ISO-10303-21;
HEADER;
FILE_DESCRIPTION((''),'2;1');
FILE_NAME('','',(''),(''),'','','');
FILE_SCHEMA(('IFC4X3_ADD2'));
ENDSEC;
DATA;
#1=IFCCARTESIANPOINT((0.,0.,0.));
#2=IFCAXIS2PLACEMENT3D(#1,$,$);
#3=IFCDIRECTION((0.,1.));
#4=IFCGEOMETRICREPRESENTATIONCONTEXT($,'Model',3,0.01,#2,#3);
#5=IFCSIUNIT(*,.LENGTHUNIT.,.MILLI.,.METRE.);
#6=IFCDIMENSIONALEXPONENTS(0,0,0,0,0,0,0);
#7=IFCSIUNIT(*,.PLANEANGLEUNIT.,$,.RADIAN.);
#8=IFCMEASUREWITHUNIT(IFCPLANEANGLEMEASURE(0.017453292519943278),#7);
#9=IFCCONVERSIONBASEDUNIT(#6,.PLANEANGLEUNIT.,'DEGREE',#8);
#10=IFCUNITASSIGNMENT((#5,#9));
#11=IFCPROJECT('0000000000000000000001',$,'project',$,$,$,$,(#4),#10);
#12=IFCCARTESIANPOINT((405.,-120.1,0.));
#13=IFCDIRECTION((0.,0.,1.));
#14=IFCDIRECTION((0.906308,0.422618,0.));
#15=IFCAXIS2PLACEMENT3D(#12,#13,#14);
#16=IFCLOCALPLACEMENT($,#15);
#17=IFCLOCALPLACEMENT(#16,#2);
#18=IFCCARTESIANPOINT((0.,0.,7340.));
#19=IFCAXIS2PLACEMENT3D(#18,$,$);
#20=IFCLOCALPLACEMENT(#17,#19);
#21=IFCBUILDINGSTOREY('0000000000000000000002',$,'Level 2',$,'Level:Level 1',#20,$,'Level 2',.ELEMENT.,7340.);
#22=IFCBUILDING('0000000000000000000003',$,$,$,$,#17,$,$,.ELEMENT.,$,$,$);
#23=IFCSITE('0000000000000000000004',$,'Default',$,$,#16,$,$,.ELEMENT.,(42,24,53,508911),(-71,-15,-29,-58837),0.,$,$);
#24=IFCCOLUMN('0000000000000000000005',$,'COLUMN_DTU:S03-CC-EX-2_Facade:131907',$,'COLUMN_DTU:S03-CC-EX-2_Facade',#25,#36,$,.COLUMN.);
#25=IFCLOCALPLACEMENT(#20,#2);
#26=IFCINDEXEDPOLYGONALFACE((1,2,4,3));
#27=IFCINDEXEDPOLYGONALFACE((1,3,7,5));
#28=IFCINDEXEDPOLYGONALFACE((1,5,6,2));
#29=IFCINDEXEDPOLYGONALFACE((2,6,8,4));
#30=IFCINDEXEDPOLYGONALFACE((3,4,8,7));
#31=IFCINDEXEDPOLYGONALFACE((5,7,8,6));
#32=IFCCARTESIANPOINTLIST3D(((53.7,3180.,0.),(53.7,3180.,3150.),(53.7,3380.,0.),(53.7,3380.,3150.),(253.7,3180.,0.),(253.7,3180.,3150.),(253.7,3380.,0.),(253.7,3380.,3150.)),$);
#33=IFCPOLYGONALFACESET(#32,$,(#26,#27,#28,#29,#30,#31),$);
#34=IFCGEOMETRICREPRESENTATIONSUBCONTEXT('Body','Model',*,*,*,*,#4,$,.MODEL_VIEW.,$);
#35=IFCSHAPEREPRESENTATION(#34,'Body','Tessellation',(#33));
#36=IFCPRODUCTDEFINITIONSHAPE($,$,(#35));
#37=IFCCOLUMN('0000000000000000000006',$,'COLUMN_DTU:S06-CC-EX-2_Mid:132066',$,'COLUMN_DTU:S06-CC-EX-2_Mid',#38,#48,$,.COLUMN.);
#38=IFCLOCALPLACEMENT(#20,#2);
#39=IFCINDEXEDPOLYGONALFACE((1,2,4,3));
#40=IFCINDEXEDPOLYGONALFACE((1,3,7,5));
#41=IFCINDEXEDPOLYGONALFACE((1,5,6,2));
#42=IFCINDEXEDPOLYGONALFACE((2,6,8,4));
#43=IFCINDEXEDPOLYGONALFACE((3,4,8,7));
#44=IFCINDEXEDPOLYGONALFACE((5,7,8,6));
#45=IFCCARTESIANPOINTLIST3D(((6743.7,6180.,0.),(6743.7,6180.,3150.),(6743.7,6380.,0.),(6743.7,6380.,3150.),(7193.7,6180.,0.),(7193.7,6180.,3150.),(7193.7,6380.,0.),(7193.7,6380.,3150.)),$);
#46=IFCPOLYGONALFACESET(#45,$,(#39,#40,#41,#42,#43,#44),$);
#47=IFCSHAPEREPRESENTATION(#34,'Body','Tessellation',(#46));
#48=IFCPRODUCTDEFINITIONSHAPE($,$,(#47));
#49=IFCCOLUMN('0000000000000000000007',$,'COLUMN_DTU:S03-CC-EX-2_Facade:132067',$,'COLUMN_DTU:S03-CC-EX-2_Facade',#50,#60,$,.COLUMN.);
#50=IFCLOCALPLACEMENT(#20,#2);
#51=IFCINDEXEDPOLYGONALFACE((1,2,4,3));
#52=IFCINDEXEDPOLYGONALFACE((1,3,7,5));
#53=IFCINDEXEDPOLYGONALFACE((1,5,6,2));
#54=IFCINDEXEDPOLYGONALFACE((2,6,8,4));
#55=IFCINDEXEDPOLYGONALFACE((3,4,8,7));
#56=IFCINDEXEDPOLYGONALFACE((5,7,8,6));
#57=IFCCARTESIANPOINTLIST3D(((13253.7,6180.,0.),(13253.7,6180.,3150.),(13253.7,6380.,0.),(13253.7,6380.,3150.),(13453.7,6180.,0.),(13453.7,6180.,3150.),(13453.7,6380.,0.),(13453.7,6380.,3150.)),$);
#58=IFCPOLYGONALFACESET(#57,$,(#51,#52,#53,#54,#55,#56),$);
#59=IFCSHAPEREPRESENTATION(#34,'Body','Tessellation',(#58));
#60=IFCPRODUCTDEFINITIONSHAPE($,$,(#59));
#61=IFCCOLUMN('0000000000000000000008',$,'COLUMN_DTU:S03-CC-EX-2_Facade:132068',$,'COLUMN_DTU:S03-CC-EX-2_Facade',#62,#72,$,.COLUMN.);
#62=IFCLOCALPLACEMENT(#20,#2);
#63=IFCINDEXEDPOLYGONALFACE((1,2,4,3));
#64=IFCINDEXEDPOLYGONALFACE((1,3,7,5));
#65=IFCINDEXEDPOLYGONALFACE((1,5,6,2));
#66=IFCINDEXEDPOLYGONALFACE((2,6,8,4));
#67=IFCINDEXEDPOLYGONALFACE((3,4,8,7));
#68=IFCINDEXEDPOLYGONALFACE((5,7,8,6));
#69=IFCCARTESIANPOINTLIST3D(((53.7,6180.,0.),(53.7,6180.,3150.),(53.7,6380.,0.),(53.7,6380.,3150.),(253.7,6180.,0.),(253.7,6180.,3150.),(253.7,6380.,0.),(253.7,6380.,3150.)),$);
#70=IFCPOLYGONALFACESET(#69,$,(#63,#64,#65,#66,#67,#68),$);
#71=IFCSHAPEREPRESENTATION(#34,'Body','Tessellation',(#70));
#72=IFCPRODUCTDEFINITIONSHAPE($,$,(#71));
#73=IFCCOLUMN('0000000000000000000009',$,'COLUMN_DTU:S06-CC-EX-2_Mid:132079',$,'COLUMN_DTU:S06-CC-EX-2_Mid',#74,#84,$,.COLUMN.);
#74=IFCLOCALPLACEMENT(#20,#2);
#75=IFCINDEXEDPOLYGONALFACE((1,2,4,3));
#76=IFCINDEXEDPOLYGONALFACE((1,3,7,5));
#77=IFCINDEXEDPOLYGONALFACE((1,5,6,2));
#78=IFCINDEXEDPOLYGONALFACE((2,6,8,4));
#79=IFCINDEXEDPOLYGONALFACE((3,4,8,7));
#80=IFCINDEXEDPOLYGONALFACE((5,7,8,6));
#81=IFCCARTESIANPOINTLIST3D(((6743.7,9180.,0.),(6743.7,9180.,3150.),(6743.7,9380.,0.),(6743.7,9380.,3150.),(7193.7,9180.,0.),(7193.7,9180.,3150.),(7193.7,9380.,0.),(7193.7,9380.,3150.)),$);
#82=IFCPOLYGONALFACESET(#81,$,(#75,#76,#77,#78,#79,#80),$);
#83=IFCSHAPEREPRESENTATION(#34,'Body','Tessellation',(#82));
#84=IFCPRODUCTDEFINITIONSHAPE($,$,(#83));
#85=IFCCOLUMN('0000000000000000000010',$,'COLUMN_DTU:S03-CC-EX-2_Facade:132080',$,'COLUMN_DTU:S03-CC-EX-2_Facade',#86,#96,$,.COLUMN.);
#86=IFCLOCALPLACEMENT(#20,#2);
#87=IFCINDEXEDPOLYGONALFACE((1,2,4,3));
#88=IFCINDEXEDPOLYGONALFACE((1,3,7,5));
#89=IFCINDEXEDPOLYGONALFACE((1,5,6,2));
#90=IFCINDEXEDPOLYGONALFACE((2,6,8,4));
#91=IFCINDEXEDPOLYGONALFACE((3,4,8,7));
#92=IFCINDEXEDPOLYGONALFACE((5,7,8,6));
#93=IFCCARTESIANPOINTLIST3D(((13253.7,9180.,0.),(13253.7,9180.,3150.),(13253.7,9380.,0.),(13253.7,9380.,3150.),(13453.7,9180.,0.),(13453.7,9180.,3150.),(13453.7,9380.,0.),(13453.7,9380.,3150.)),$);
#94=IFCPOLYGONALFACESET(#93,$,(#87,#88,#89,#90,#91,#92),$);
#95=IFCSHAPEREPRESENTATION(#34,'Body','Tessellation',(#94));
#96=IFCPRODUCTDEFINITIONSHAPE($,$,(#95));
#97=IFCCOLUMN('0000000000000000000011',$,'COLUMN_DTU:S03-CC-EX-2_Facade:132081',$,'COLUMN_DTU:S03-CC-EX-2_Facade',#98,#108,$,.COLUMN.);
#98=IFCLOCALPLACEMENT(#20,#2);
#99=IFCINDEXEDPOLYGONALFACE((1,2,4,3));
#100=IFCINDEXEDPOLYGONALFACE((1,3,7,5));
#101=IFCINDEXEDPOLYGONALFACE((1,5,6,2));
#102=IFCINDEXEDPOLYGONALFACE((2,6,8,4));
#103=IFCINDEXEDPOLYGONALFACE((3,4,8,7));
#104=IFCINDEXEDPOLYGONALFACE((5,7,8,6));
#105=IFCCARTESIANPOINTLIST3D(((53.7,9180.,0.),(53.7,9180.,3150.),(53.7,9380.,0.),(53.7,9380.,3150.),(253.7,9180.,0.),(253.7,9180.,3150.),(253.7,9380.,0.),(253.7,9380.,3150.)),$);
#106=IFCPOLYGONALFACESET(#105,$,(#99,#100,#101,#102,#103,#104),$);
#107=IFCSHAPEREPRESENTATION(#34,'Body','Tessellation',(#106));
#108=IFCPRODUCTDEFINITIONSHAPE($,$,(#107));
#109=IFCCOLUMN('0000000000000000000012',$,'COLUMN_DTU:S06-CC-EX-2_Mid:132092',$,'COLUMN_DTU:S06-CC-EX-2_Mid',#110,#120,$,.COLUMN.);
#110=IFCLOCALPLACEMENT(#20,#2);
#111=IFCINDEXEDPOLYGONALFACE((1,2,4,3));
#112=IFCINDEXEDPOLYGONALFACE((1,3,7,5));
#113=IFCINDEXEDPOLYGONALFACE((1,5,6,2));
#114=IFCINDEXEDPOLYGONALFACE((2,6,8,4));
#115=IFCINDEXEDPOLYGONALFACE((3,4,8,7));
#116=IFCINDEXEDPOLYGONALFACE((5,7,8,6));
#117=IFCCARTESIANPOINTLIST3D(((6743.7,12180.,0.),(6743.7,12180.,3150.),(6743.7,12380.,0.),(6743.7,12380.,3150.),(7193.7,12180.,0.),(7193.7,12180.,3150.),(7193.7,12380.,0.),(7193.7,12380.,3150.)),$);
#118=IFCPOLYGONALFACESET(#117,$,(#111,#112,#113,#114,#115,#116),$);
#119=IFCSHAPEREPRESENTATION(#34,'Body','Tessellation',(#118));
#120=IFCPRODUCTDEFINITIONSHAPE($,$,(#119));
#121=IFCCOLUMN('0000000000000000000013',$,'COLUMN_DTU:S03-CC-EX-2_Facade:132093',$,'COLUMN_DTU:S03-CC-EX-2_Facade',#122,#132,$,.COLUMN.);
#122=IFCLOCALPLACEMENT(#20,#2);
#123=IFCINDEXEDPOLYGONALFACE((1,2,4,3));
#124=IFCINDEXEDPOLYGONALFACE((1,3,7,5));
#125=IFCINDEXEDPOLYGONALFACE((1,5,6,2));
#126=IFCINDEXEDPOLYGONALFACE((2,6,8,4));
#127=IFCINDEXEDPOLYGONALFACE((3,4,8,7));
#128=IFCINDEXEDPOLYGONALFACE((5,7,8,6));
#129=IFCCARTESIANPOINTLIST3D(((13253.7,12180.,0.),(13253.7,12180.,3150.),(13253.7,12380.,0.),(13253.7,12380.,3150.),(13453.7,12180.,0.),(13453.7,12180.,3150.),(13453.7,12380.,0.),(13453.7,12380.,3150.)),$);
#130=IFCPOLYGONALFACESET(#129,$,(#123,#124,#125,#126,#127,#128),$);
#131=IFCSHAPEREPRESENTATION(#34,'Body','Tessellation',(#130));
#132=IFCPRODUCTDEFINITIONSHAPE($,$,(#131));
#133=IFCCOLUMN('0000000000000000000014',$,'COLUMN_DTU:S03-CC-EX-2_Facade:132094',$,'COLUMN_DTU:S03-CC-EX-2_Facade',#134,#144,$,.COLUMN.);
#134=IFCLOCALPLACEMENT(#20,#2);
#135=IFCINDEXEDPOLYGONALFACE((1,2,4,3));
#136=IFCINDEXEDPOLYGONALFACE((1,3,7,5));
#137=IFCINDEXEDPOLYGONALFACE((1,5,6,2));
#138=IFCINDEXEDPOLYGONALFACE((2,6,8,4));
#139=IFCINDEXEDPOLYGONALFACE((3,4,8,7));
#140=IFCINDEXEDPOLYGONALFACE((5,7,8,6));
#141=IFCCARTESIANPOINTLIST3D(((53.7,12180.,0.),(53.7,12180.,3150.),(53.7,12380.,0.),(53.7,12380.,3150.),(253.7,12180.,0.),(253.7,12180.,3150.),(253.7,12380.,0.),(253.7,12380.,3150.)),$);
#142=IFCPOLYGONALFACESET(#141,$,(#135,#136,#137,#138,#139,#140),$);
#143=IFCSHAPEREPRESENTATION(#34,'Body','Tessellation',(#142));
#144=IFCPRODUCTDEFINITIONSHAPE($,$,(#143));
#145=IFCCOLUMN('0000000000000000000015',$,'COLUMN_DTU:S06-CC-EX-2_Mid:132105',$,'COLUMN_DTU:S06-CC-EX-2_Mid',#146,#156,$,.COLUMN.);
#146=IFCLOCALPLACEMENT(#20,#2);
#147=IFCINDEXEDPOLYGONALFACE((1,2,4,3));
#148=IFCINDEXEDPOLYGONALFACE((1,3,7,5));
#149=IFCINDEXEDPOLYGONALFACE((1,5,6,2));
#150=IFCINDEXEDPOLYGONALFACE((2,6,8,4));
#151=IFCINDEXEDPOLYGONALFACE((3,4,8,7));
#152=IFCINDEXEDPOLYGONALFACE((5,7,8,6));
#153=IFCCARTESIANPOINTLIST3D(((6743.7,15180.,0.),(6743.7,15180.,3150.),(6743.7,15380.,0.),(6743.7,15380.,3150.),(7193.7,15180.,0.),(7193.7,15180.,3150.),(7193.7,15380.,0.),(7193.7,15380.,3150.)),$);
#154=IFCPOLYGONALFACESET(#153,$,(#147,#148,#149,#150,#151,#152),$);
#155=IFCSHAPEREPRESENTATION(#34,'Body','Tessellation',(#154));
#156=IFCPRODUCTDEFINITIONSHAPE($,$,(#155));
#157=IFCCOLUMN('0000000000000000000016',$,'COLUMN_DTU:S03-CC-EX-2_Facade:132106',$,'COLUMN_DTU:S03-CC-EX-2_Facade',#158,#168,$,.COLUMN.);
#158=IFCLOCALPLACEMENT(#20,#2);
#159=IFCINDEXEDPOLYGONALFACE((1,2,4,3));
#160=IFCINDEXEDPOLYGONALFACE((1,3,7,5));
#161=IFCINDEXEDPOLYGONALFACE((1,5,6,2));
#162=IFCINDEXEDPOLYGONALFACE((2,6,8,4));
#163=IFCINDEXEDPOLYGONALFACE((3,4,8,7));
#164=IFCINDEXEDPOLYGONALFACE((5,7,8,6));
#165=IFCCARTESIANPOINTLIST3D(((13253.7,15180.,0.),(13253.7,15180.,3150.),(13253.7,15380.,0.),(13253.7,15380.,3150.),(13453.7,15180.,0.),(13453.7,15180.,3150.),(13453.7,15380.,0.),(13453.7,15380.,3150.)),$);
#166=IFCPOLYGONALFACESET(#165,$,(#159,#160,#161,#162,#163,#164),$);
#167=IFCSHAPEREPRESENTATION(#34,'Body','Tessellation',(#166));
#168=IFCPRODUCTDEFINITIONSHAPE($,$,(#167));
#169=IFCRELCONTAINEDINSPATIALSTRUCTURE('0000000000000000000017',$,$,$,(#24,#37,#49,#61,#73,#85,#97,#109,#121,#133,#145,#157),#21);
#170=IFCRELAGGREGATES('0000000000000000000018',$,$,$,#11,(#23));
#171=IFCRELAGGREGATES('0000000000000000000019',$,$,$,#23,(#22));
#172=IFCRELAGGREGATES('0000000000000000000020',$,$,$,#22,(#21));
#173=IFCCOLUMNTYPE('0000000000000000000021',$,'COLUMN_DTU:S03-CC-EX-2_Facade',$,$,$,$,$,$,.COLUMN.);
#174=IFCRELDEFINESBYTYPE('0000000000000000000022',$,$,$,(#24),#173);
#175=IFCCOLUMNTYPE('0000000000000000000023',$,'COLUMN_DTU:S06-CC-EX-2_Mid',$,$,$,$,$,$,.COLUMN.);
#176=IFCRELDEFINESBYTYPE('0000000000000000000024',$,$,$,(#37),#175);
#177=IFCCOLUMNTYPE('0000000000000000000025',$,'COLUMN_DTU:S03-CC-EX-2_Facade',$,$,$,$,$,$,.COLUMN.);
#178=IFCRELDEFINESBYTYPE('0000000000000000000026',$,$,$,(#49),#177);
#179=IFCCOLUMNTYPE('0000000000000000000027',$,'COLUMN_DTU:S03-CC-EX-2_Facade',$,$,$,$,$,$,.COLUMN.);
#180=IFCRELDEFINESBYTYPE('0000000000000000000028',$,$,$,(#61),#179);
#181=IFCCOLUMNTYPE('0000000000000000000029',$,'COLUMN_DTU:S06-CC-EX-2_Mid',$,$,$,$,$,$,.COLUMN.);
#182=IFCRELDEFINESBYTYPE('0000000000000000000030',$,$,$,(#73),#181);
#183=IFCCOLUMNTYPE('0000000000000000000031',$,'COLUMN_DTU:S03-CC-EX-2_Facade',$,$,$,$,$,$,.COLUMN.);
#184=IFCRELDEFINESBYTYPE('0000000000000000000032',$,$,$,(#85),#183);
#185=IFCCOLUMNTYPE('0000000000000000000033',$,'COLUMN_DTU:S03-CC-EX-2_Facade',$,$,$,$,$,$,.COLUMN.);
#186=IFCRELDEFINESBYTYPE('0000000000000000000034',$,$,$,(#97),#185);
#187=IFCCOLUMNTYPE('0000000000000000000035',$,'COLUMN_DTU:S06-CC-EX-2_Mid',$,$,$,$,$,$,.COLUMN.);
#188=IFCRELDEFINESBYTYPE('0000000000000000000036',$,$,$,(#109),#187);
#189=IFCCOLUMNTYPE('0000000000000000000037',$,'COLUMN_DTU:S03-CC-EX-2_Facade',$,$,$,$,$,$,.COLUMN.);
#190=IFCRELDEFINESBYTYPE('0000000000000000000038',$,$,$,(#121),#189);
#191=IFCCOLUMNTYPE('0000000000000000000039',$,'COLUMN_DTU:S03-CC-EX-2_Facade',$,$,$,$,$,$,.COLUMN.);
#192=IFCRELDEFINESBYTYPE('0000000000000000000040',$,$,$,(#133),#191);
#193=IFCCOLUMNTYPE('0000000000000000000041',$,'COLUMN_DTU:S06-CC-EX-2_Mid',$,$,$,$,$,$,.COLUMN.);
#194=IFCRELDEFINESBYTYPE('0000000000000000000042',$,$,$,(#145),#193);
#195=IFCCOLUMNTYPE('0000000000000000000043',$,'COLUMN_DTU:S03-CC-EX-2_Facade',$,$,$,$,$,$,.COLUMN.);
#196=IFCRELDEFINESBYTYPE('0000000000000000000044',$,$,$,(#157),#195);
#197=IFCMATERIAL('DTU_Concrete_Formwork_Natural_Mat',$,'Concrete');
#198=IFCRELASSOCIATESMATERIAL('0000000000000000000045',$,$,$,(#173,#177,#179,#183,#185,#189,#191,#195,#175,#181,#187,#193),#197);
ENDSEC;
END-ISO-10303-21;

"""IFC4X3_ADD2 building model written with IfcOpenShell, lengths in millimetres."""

from ifc_helpers import new_model, entity, si_unit, converted_unit, direction, frame, frame_2d, origin, origin_2d_with_axis, place, context, subcontext, project, spatial, rectangle, extrude, source, transform, mapped, material, material_profile, profile_set, type_object, type_shapes, element, save


model = new_model("IFC4X3_ADD2")

# Units and contexts
model_context = context("Model", 3, precision=0.01, world=origin(), true_north=direction((0.0, 1.0)))
body_context = subcontext(model_context, "Body", "Model", "MODEL_VIEW")
ifc_project = project(units=[si_unit("LENGTHUNIT", "METRE", prefix="MILLI"), converted_unit("PLANEANGLEUNIT", "DEGREE", entity("IfcPlaneAngleMeasure", 0.017453292519943278), si_unit("PLANEANGLEUNIT", "RADIAN"), dimensions=[0, 0, 0, 0, 0, 0, 0])], contexts=[model_context])

# Site, building, storey
site_placement = place(None, frame((405.0, -120.1, 0.0), z_axis=(0.0, 0.0, 1.0), x_axis=(0.906308, 0.422618, 0.0)))
site = spatial("IfcSite", under=ifc_project, at=site_placement, Name="Default", CompositionType="ELEMENT", RefLatitude=(42, 24, 53, 508911), RefLongitude=(-71, -15, -29, -58837), RefElevation=0.0)
building_placement = place(site_placement, origin())
building = spatial("IfcBuilding", under=site, at=building_placement, CompositionType="ELEMENT")
storey_placement = place(building_placement, frame((0.0, 0.0, 7340.0)))
storey = spatial("IfcBuildingStorey", under=building, at=storey_placement, Name="Level 2", ObjectType="Level:Level 1", LongName="Level 2", CompositionType="ELEMENT", Elevation=7340.0)

# Columns
ifc_material = material(Name="DTU_Concrete_Formwork_Natural_Mat", Category="Concrete")
ifc_material_profile_1 = material_profile(ifc_material, rectangle(XDim=200.0, YDim=200.0, at=frame_2d((0.0, 0.0), x_axis=(1.0, 0.0))), Name="S03-CC-EX-2_Facade")
ifc_profile_set_1 = profile_set([ifc_material_profile_1], Name="S03-CC-EX-2_Facade")
column_type_1 = type_object("IfcColumnType", Name="COLUMN_DTU:S03-CC-EX-2_Facade", PredefinedType="COLUMN", material=ifc_profile_set_1)
shared_shape_1 = source(origin(), body_context, "Body", "SweptSolid", [
    extrude(rectangle(XDim=200.0, YDim=200.0, at=frame_2d((0.0, 0.0), x_axis=(1.0, 0.0))), frame((153.7, 3280.0, 7340.0), z_axis=(0.0, 0.0, 1.0), x_axis=(0.0, -1.0, 0.0)), (0.0, 0.0, 1.0), 3150.0),
])
type_shapes(column_type_1, [shared_shape_1])
column_1_placement = place(storey_placement, frame((0.0, 0.0, -7340.0)))
element("IfcColumn", 1, at=column_1_placement, inside=storey, type_object=column_type_1, Name="COLUMN_DTU:S03-CC-EX-2_Facade:131907", ObjectType="COLUMN_DTU:S03-CC-EX-2_Facade", PredefinedType="COLUMN", context=body_context, shape_type="MappedRepresentation", body=[
    mapped(shared_shape_1, transform((0.0, 0.0, 0.0), scale=1.0)),
])
ifc_material_profile_2 = material_profile(ifc_material, rectangle(XDim=200.0, YDim=450.0, at=origin_2d_with_axis()), Name="S06-CC-EX-2_Mid")
ifc_profile_set_2 = profile_set([ifc_material_profile_2], Name="S06-CC-EX-2_Mid")
column_type_2 = type_object("IfcColumnType", Name="COLUMN_DTU:S06-CC-EX-2_Mid", PredefinedType="COLUMN", material=ifc_profile_set_2)
shared_shape_2 = source(origin(), body_context, "Body", "SweptSolid", [
    extrude(rectangle(XDim=200.0, YDim=450.0, at=origin_2d_with_axis()), frame((6968.7, 6280.0, 7340.0), z_axis=(0.0, 0.0, 1.0), x_axis=(0.0, 1.0, 0.0)), (0.0, 0.0, 1.0), 3150.0),
])
type_shapes(column_type_2, [shared_shape_2])
column_2_placement = place(storey_placement, frame((0.0, 0.0, -7340.0)))
element("IfcColumn", 2, at=column_2_placement, inside=storey, type_object=column_type_2, Name="COLUMN_DTU:S06-CC-EX-2_Mid:132066", ObjectType="COLUMN_DTU:S06-CC-EX-2_Mid", PredefinedType="COLUMN", context=body_context, shape_type="MappedRepresentation", body=[
    mapped(shared_shape_2, transform((0.0, 0.0, 0.0), scale=1.0)),
])
column_type_3 = type_object("IfcColumnType", Name="COLUMN_DTU:S03-CC-EX-2_Facade", PredefinedType="COLUMN", material=ifc_profile_set_1)
shared_shape_3 = source(origin(), body_context, "Body", "SweptSolid", [
    extrude(rectangle(XDim=200.0, YDim=200.0, at=frame_2d((0.0, 0.0), x_axis=(1.0, 0.0))), frame((13353.7, 6280.0, 7340.0), z_axis=(0.0, 0.0, 1.0), x_axis=(0.0, -1.0, 0.0)), (0.0, 0.0, 1.0), 3150.0),
])
type_shapes(column_type_3, [shared_shape_3])
column_3_placement = place(storey_placement, frame((0.0, 0.0, -7340.0)))
element("IfcColumn", 3, at=column_3_placement, inside=storey, type_object=column_type_3, Name="COLUMN_DTU:S03-CC-EX-2_Facade:132067", ObjectType="COLUMN_DTU:S03-CC-EX-2_Facade", PredefinedType="COLUMN", context=body_context, shape_type="MappedRepresentation", body=[
    mapped(shared_shape_3, transform((0.0, 0.0, 0.0), scale=1.0)),
])
column_type_4 = type_object("IfcColumnType", Name="COLUMN_DTU:S03-CC-EX-2_Facade", PredefinedType="COLUMN", material=ifc_profile_set_1)
shared_shape_4 = source(origin(), body_context, "Body", "SweptSolid", [
    extrude(rectangle(XDim=200.0, YDim=200.0, at=frame_2d((0.0, 0.0), x_axis=(1.0, 0.0))), frame((153.7, 6280.0, 7340.0), z_axis=(0.0, 0.0, 1.0), x_axis=(0.0, -1.0, 0.0)), (0.0, 0.0, 1.0), 3150.0),
])
type_shapes(column_type_4, [shared_shape_4])
column_4_placement = place(storey_placement, frame((0.0, 0.0, -7340.0)))
element("IfcColumn", 4, at=column_4_placement, inside=storey, type_object=column_type_4, Name="COLUMN_DTU:S03-CC-EX-2_Facade:132068", ObjectType="COLUMN_DTU:S03-CC-EX-2_Facade", PredefinedType="COLUMN", context=body_context, shape_type="MappedRepresentation", body=[
    mapped(shared_shape_4, transform((0.0, 0.0, 0.0), scale=1.0)),
])
column_type_5 = type_object("IfcColumnType", Name="COLUMN_DTU:S06-CC-EX-2_Mid", PredefinedType="COLUMN", material=ifc_profile_set_2)
shared_shape_5 = source(origin(), body_context, "Body", "SweptSolid", [
    extrude(rectangle(XDim=200.0, YDim=450.0, at=origin_2d_with_axis()), frame((6968.7, 9280.0, 7340.0), z_axis=(0.0, 0.0, 1.0), x_axis=(0.0, 1.0, 0.0)), (0.0, 0.0, 1.0), 3150.0),
])
type_shapes(column_type_5, [shared_shape_5])
column_5_placement = place(storey_placement, frame((0.0, 0.0, -7340.0)))
element("IfcColumn", 5, at=column_5_placement, inside=storey, type_object=column_type_5, Name="COLUMN_DTU:S06-CC-EX-2_Mid:132079", ObjectType="COLUMN_DTU:S06-CC-EX-2_Mid", PredefinedType="COLUMN", context=body_context, shape_type="MappedRepresentation", body=[
    mapped(shared_shape_5, transform((0.0, 0.0, 0.0), scale=1.0)),
])
column_type_6 = type_object("IfcColumnType", Name="COLUMN_DTU:S03-CC-EX-2_Facade", PredefinedType="COLUMN", material=ifc_profile_set_1)
shared_shape_6 = source(origin(), body_context, "Body", "SweptSolid", [
    extrude(rectangle(XDim=200.0, YDim=200.0, at=frame_2d((0.0, 0.0), x_axis=(1.0, 0.0))), frame((13353.7, 9280.0, 7340.0), z_axis=(0.0, 0.0, 1.0), x_axis=(0.0, -1.0, 0.0)), (0.0, 0.0, 1.0), 3150.0),
])
type_shapes(column_type_6, [shared_shape_6])
column_6_placement = place(storey_placement, frame((0.0, 0.0, -7340.0)))
element("IfcColumn", 6, at=column_6_placement, inside=storey, type_object=column_type_6, Name="COLUMN_DTU:S03-CC-EX-2_Facade:132080", ObjectType="COLUMN_DTU:S03-CC-EX-2_Facade", PredefinedType="COLUMN", context=body_context, shape_type="MappedRepresentation", body=[
    mapped(shared_shape_6, transform((0.0, 0.0, 0.0), scale=1.0)),
])
column_type_7 = type_object("IfcColumnType", Name="COLUMN_DTU:S03-CC-EX-2_Facade", PredefinedType="COLUMN", material=ifc_profile_set_1)
shared_shape_7 = source(origin(), body_context, "Body", "SweptSolid", [
    extrude(rectangle(XDim=200.0, YDim=200.0, at=frame_2d((0.0, 0.0), x_axis=(1.0, 0.0))), frame((153.7, 9280.0, 7340.0), z_axis=(0.0, 0.0, 1.0), x_axis=(0.0, -1.0, 0.0)), (0.0, 0.0, 1.0), 3150.0),
])
type_shapes(column_type_7, [shared_shape_7])
column_7_placement = place(storey_placement, frame((0.0, 0.0, -7340.0)))
element("IfcColumn", 7, at=column_7_placement, inside=storey, type_object=column_type_7, Name="COLUMN_DTU:S03-CC-EX-2_Facade:132081", ObjectType="COLUMN_DTU:S03-CC-EX-2_Facade", PredefinedType="COLUMN", context=body_context, shape_type="MappedRepresentation", body=[
    mapped(shared_shape_7, transform((0.0, 0.0, 0.0), scale=1.0)),
])
column_type_8 = type_object("IfcColumnType", Name="COLUMN_DTU:S06-CC-EX-2_Mid", PredefinedType="COLUMN", material=ifc_profile_set_2)
shared_shape_8 = source(origin(), body_context, "Body", "SweptSolid", [
    extrude(rectangle(XDim=200.0, YDim=450.0, at=frame_2d((0.0, 0.0), x_axis=(1.0, 0.0))), frame((6968.7, 12280.0, 7340.0), z_axis=(0.0, 0.0, 1.0), x_axis=(0.0, 1.0, 0.0)), (0.0, 0.0, 1.0), 3150.0),
])
type_shapes(column_type_8, [shared_shape_8])
column_8_placement = place(storey_placement, frame((0.0, 0.0, -7340.0)))
element("IfcColumn", 8, at=column_8_placement, inside=storey, type_object=column_type_8, Name="COLUMN_DTU:S06-CC-EX-2_Mid:132092", ObjectType="COLUMN_DTU:S06-CC-EX-2_Mid", PredefinedType="COLUMN", context=body_context, shape_type="MappedRepresentation", body=[
    mapped(shared_shape_8, transform((0.0, 0.0, 0.0), scale=1.0)),
])
column_type_9 = type_object("IfcColumnType", Name="COLUMN_DTU:S03-CC-EX-2_Facade", PredefinedType="COLUMN", material=ifc_profile_set_1)
shared_shape_9 = source(origin(), body_context, "Body", "SweptSolid", [
    extrude(rectangle(XDim=200.0, YDim=200.0, at=frame_2d((0.0, 0.0), x_axis=(1.0, 0.0))), frame((13353.7, 12280.0, 7340.0), z_axis=(0.0, 0.0, 1.0), x_axis=(0.0, -1.0, 0.0)), (0.0, 0.0, 1.0), 3150.0),
])
type_shapes(column_type_9, [shared_shape_9])
column_9_placement = place(storey_placement, frame((0.0, 0.0, -7340.0)))
element("IfcColumn", 9, at=column_9_placement, inside=storey, type_object=column_type_9, Name="COLUMN_DTU:S03-CC-EX-2_Facade:132093", ObjectType="COLUMN_DTU:S03-CC-EX-2_Facade", PredefinedType="COLUMN", context=body_context, shape_type="MappedRepresentation", body=[
    mapped(shared_shape_9, transform((0.0, 0.0, 0.0), scale=1.0)),
])
column_type_10 = type_object("IfcColumnType", Name="COLUMN_DTU:S03-CC-EX-2_Facade", PredefinedType="COLUMN", material=ifc_profile_set_1)
shared_shape_10 = source(origin(), body_context, "Body", "SweptSolid", [
    extrude(rectangle(XDim=200.0, YDim=200.0, at=frame_2d((0.0, 0.0), x_axis=(1.0, 0.0))), frame((153.7, 12280.0, 7340.0), z_axis=(0.0, 0.0, 1.0), x_axis=(0.0, -1.0, 0.0)), (0.0, 0.0, 1.0), 3150.0),
])
type_shapes(column_type_10, [shared_shape_10])
column_10_placement = place(storey_placement, frame((0.0, 0.0, -7340.0)))
element("IfcColumn", 10, at=column_10_placement, inside=storey, type_object=column_type_10, Name="COLUMN_DTU:S03-CC-EX-2_Facade:132094", ObjectType="COLUMN_DTU:S03-CC-EX-2_Facade", PredefinedType="COLUMN", context=body_context, shape_type="MappedRepresentation", body=[
    mapped(shared_shape_10, transform((0.0, 0.0, 0.0), scale=1.0)),
])
column_type_11 = type_object("IfcColumnType", Name="COLUMN_DTU:S06-CC-EX-2_Mid", PredefinedType="COLUMN", material=ifc_profile_set_2)
shared_shape_11 = source(origin(), body_context, "Body", "SweptSolid", [
    extrude(rectangle(XDim=200.0, YDim=450.0, at=frame_2d((0.0, 0.0), x_axis=(1.0, 0.0))), frame((6968.7, 15280.0, 7340.0), z_axis=(0.0, 0.0, 1.0), x_axis=(0.0, 1.0, 0.0)), (0.0, 0.0, 1.0), 3150.0),
])
type_shapes(column_type_11, [shared_shape_11])
column_11_placement = place(storey_placement, frame((0.0, 0.0, -7340.0)))
element("IfcColumn", 11, at=column_11_placement, inside=storey, type_object=column_type_11, Name="COLUMN_DTU:S06-CC-EX-2_Mid:132105", ObjectType="COLUMN_DTU:S06-CC-EX-2_Mid", PredefinedType="COLUMN", context=body_context, shape_type="MappedRepresentation", body=[
    mapped(shared_shape_11, transform((0.0, 0.0, 0.0), scale=1.0)),
])
column_type_12 = type_object("IfcColumnType", Name="COLUMN_DTU:S03-CC-EX-2_Facade", PredefinedType="COLUMN", material=ifc_profile_set_1)
shared_shape_12 = source(origin(), body_context, "Body", "SweptSolid", [
    extrude(rectangle(XDim=200.0, YDim=200.0, at=frame_2d((0.0, 0.0), x_axis=(1.0, 0.0))), frame((13353.7, 15280.0, 7340.0), z_axis=(0.0, 0.0, 1.0), x_axis=(0.0, -1.0, 0.0)), (0.0, 0.0, 1.0), 3150.0),
])
type_shapes(column_type_12, [shared_shape_12])
column_12_placement = place(storey_placement, frame((0.0, 0.0, -7340.0)))
element("IfcColumn", 12, at=column_12_placement, inside=storey, type_object=column_type_12, Name="COLUMN_DTU:S03-CC-EX-2_Facade:132106", ObjectType="COLUMN_DTU:S03-CC-EX-2_Facade", PredefinedType="COLUMN", context=body_context, shape_type="MappedRepresentation", body=[
    mapped(shared_shape_12, transform((0.0, 0.0, 0.0), scale=1.0)),
])

save(model, "model.ifc")
